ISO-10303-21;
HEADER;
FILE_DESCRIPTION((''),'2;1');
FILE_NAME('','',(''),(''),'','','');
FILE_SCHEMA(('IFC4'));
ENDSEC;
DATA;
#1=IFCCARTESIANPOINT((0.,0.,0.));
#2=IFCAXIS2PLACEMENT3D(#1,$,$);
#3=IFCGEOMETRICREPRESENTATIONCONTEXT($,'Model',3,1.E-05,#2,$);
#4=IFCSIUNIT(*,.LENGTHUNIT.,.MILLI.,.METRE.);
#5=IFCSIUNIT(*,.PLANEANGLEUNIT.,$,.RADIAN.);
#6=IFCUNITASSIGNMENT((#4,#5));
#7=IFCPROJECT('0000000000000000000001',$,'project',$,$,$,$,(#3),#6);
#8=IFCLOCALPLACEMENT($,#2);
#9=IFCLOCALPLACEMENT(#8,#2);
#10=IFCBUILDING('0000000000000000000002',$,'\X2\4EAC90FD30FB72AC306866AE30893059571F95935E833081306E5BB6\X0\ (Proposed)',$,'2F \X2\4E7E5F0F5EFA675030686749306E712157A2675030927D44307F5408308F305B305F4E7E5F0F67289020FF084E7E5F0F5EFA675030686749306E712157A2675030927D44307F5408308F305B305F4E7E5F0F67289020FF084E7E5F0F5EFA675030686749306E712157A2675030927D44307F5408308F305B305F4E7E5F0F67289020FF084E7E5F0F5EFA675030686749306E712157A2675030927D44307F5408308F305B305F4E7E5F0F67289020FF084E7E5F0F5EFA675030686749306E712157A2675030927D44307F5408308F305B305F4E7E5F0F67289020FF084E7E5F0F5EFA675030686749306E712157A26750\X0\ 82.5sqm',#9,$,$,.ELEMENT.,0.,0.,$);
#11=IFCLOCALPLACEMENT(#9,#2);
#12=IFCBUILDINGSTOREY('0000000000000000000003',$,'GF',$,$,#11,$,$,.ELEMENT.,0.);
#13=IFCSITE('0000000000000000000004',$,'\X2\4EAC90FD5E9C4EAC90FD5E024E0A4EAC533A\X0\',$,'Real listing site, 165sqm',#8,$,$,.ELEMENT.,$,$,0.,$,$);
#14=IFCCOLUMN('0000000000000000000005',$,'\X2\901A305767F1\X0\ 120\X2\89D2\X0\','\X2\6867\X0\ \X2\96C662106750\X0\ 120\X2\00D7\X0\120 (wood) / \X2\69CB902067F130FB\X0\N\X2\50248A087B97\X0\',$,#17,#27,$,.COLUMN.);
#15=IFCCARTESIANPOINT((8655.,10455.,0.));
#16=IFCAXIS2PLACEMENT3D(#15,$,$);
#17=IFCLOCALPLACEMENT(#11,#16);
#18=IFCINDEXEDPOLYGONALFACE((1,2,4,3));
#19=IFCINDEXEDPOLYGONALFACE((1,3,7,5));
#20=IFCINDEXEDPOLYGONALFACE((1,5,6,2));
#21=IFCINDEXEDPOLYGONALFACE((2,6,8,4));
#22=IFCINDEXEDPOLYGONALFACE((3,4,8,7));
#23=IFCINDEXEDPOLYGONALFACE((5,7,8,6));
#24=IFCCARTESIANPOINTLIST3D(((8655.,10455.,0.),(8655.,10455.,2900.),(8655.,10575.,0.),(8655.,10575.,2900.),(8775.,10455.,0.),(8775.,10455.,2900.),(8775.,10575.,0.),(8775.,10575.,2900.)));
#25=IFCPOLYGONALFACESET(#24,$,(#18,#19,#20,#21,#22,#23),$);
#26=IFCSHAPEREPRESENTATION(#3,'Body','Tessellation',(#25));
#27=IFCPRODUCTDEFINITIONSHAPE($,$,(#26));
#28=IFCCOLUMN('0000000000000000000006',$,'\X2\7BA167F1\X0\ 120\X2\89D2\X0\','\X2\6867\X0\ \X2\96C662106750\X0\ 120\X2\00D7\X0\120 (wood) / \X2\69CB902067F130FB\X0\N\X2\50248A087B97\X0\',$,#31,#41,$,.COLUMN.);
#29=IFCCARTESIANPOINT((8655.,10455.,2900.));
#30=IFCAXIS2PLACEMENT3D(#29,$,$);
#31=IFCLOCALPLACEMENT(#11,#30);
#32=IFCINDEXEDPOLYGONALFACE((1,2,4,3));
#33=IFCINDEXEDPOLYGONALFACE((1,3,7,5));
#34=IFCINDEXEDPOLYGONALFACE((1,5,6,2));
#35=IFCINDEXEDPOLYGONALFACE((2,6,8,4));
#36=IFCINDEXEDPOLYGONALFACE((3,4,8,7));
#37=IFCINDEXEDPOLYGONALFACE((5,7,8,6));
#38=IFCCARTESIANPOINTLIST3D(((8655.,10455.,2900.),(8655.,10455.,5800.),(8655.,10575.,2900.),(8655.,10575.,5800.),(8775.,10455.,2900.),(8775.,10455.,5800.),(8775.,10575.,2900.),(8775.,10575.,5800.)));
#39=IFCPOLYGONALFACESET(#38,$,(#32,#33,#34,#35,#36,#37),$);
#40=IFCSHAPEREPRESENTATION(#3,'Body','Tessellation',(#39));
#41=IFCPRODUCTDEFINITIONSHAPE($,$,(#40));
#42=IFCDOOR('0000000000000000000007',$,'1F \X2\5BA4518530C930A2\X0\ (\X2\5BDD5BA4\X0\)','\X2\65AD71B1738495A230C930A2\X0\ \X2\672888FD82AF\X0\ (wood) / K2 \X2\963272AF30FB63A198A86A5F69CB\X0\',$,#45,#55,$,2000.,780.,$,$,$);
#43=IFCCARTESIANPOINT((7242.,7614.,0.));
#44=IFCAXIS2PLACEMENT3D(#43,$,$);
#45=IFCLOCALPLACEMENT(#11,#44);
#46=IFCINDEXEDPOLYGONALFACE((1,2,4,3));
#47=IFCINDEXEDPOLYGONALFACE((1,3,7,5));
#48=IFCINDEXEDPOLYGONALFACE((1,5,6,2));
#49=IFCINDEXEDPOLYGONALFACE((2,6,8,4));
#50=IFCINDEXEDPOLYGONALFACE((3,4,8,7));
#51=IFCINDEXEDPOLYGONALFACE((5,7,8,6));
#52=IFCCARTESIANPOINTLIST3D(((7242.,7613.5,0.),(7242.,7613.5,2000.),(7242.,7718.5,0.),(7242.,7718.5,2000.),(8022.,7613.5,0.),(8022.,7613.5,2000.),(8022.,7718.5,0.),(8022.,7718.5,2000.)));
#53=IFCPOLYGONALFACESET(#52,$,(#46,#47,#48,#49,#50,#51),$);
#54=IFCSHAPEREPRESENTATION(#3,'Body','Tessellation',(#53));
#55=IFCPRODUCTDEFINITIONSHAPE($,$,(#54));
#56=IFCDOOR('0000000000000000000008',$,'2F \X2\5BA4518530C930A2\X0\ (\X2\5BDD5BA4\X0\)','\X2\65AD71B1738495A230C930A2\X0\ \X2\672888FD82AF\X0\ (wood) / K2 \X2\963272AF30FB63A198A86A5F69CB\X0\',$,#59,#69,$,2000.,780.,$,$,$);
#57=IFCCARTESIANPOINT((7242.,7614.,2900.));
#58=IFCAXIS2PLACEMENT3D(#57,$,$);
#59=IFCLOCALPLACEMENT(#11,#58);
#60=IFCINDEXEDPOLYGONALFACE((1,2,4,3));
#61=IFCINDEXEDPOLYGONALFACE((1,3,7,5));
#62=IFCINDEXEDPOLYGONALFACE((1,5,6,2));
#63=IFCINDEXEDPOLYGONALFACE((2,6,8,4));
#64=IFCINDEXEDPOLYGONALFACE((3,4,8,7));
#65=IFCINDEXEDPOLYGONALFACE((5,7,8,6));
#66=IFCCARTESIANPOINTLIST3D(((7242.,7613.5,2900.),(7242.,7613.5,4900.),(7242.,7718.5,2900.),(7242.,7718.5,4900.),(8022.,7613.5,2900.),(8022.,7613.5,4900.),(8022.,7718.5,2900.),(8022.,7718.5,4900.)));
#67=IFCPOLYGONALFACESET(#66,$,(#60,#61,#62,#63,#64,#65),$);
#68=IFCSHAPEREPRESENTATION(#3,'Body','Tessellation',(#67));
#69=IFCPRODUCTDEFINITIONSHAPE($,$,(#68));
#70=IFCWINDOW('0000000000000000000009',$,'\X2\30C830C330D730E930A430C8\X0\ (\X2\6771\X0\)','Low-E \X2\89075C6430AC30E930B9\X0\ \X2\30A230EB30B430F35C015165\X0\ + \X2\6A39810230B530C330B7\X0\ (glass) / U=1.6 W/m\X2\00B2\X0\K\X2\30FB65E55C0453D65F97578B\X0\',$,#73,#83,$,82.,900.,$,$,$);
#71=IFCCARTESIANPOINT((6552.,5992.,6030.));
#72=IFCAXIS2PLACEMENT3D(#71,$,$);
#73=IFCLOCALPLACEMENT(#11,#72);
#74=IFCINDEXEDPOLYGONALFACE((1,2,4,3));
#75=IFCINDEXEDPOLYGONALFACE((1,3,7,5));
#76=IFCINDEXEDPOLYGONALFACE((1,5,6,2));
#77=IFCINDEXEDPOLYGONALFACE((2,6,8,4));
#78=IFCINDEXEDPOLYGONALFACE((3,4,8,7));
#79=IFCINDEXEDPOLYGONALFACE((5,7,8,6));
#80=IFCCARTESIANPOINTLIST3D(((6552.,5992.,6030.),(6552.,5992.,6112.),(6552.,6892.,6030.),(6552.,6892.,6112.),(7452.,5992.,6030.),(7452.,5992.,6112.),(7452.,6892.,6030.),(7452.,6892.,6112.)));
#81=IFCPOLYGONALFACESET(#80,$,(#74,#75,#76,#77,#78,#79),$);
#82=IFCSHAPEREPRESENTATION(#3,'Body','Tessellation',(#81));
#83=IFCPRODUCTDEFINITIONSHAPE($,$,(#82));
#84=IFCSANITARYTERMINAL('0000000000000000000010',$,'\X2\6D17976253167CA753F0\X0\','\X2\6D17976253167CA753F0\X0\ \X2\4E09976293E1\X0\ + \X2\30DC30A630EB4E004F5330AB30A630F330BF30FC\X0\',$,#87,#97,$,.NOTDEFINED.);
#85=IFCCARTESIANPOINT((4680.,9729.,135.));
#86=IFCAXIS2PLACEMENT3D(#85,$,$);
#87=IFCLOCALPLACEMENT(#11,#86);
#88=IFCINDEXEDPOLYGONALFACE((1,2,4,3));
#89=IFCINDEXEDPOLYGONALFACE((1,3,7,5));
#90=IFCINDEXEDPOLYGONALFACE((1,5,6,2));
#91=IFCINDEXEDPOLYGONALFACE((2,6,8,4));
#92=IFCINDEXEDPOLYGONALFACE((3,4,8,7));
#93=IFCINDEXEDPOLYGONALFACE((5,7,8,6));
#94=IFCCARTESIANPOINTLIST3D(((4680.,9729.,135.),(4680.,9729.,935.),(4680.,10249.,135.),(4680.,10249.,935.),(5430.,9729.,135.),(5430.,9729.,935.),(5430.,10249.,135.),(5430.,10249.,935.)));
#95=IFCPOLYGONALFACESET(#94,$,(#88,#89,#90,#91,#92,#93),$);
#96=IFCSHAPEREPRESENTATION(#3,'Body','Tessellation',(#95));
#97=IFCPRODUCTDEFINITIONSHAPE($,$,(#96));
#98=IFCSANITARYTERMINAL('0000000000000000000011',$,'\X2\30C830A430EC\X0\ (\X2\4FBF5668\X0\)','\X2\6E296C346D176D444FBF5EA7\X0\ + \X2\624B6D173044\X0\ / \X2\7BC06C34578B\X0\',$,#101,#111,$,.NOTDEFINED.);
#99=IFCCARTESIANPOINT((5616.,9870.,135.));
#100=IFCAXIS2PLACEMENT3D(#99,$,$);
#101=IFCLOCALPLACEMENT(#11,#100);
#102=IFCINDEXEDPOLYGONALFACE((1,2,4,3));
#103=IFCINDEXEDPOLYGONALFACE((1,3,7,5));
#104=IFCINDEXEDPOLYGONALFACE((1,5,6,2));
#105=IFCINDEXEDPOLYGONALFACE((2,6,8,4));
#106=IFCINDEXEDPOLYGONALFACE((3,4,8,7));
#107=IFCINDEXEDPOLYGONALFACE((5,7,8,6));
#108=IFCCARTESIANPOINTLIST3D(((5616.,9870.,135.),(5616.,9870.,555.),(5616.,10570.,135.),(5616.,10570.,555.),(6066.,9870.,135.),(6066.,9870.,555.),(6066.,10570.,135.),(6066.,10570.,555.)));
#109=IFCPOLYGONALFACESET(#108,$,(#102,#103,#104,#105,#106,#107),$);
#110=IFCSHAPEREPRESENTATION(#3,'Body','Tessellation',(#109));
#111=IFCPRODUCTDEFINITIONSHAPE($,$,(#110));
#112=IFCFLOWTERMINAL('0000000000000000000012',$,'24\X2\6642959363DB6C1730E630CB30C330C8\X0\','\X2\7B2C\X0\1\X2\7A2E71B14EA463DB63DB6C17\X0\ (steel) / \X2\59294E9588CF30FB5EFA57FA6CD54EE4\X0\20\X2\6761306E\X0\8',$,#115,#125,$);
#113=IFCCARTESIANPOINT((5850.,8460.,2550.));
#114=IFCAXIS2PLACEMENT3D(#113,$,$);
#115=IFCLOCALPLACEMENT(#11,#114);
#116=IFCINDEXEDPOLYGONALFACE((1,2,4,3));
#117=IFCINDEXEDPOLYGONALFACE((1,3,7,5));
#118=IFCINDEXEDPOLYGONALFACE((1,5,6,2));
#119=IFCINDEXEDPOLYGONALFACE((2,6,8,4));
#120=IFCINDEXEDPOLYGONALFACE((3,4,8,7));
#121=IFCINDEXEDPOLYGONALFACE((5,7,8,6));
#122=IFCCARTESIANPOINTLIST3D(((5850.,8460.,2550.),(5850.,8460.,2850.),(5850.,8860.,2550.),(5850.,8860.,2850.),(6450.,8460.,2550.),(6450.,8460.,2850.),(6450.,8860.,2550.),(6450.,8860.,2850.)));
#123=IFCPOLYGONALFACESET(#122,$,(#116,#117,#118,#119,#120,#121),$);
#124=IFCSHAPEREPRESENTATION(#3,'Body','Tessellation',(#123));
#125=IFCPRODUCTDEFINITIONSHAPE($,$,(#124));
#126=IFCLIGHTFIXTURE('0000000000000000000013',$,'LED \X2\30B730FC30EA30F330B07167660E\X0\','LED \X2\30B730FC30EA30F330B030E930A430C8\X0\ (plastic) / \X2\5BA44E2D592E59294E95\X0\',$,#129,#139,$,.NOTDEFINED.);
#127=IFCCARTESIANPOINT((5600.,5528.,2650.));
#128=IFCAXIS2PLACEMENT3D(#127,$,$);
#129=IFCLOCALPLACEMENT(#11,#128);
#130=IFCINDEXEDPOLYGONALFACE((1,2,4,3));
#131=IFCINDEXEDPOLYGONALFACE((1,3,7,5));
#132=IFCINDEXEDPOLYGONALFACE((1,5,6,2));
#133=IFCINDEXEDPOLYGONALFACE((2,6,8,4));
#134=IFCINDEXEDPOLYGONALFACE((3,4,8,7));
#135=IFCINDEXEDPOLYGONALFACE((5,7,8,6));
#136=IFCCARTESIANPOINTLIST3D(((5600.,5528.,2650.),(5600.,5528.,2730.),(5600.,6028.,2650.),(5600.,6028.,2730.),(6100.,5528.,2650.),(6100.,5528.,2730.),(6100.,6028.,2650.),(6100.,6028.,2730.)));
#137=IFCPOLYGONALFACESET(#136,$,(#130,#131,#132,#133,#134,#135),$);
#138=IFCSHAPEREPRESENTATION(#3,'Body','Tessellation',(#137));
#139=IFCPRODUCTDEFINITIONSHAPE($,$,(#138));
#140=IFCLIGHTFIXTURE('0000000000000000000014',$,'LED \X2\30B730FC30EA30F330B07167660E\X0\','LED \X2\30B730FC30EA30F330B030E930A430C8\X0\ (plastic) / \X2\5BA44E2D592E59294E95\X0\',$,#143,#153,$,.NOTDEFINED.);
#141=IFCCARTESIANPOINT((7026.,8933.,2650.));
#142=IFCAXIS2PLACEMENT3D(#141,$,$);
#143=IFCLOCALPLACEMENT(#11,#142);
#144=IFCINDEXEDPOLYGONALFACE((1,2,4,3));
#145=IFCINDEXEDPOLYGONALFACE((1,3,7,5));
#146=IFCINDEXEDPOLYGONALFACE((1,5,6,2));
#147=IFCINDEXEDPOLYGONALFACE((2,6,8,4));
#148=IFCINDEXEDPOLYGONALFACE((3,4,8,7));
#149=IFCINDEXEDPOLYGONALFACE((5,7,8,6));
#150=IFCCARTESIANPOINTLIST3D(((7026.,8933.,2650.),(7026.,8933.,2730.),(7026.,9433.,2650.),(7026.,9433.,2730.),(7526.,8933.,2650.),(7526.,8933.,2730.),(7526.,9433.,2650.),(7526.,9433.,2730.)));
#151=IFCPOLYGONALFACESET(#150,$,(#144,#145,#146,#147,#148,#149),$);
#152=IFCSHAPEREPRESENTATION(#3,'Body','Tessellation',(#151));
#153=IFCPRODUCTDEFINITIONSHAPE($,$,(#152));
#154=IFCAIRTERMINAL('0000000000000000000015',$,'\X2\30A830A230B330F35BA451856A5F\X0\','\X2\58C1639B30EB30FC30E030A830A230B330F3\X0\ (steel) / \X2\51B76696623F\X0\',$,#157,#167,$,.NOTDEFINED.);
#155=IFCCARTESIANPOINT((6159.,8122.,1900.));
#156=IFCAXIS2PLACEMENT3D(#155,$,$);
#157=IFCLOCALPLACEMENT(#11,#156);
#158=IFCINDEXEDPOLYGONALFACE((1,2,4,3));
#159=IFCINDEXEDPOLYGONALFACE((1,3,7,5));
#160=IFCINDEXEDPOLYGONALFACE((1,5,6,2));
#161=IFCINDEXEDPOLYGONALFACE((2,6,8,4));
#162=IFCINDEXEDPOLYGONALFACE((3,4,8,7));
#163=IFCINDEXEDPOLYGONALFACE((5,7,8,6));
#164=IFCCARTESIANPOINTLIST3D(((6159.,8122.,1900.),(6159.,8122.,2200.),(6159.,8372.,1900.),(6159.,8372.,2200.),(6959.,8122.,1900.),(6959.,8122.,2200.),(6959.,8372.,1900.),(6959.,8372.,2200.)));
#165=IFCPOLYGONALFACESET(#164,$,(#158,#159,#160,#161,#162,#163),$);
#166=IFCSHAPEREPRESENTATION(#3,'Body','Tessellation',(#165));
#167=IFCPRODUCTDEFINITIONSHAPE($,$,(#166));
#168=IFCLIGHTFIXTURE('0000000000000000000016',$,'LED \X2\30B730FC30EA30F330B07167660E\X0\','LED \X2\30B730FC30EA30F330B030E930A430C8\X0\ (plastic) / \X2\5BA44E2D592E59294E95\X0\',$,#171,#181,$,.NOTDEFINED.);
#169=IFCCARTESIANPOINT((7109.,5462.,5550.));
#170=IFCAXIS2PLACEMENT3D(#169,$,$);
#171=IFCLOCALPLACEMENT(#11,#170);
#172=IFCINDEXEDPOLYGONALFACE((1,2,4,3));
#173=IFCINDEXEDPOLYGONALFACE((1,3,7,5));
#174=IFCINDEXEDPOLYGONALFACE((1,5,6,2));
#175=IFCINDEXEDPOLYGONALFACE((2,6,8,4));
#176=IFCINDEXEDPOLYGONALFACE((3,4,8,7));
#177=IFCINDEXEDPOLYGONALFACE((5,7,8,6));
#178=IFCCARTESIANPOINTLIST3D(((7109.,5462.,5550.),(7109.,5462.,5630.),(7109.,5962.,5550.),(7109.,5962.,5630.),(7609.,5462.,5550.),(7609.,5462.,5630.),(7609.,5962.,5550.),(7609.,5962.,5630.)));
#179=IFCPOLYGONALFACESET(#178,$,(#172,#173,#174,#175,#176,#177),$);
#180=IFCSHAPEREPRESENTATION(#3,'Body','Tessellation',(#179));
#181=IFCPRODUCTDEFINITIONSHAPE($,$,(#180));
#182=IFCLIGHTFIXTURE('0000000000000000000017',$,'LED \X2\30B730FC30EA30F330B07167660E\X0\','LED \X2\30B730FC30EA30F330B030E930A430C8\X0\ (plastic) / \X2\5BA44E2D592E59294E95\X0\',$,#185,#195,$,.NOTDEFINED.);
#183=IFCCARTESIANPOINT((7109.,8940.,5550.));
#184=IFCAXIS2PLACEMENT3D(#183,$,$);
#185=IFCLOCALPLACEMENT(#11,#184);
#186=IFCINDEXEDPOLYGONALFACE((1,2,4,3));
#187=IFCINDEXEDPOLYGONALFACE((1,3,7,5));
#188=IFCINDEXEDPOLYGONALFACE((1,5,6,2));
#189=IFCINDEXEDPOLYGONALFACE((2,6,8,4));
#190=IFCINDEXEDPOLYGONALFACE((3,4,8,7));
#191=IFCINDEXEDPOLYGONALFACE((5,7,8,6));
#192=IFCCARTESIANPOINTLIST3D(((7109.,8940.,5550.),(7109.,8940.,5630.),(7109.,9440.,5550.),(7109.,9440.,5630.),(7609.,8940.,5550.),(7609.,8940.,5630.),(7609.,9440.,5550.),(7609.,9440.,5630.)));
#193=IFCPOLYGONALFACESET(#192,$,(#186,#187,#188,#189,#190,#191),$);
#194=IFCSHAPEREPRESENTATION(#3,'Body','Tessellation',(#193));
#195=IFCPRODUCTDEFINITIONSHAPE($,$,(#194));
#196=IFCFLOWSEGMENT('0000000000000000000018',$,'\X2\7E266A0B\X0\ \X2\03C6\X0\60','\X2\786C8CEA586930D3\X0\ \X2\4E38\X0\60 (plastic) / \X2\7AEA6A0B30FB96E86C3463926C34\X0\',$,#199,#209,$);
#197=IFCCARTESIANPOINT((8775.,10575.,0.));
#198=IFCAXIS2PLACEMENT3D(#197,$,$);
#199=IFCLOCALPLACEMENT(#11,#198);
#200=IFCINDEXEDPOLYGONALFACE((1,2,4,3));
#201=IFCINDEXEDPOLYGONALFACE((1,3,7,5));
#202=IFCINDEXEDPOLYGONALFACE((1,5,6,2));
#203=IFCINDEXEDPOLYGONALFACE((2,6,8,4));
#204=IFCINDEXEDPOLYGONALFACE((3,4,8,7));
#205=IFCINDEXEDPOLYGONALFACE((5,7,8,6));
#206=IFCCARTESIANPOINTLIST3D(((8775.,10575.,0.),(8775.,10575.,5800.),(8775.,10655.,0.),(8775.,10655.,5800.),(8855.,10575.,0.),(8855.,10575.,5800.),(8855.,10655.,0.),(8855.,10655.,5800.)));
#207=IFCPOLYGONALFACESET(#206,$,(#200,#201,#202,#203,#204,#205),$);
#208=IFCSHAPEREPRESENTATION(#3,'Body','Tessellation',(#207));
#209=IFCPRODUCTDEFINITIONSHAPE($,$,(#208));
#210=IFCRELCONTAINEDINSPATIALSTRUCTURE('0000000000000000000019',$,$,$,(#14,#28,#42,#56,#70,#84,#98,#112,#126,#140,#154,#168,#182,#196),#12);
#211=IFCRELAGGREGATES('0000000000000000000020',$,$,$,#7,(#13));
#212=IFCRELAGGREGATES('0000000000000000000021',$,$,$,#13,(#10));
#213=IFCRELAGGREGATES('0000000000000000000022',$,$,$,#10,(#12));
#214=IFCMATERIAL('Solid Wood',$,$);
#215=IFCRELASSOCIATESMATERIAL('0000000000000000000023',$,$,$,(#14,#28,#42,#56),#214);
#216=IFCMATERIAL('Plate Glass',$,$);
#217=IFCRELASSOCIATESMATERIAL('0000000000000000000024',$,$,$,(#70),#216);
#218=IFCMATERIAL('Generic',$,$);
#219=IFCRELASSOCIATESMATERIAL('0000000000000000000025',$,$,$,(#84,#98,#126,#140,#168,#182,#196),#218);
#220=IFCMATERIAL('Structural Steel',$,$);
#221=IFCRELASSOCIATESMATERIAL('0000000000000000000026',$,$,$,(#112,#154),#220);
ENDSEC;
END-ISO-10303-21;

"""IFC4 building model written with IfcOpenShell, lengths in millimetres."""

from ifc_helpers import new_model, si_unit, frame, frame_2d, origin, place, context, project, spatial, rectangle, extrude, material, element, save


model = new_model("IFC4")

# Units and contexts
model_context = context("Model", 3, precision=1e-05, world=origin())
ifc_project = project(units=[si_unit("LENGTHUNIT", "METRE", prefix="MILLI"), si_unit("PLANEANGLEUNIT", "RADIAN")], contexts=[model_context])

# Site, building, storey
site_placement = place(None, origin())
site = spatial("IfcSite", under=ifc_project, at=site_placement, Name="京都府京都市上京区", ObjectType="Real listing site, 165sqm", CompositionType="ELEMENT", RefElevation=0.0)
building_placement = place(site_placement, origin())
building = spatial("IfcBuilding", under=site, at=building_placement, Name="京都・犬と暮らす土間広めの家 (Proposed)", ObjectType="2F 乾式建材と杉の無垢材を組み合わせた乾式木造（乾式建材と杉の無垢材を組み合わせた乾式木造（乾式建材と杉の無垢材を組み合わせた乾式木造（乾式建材と杉の無垢材を組み合わせた乾式木造（乾式建材と杉の無垢材を組み合わせた乾式木造（乾式建材と杉の無垢材 82.5sqm", CompositionType="ELEMENT", ElevationOfRefHeight=0.0, ElevationOfTerrain=0.0)
storey_placement = place(building_placement, origin())
storey = spatial("IfcBuildingStorey", under=building, at=storey_placement, Name="GF", CompositionType="ELEMENT", Elevation=0.0)

# Columns
ifc_material_1 = material(Name="Solid Wood")
column_1_placement = place(storey_placement, frame((8655.0, 10455.0, 0.0)))
element("IfcColumn", 1, at=column_1_placement, inside=storey, material=ifc_material_1, Name="通し柱 120角", Description="桧 集成材 120×120 (wood) / 構造柱・N値計算", PredefinedType="COLUMN", context=model_context, shape_type="SweptSolid", body=[
    extrude(rectangle(XDim=120.0, YDim=120.0, at=frame_2d((60.0, 60.0))), frame((8655.0, 10455.0, 0.0)), (0.0, 0.0, 1.0), 2900.0),
])
column_2_placement = place(storey_placement, frame((8655.0, 10455.0, 2900.0)))
element("IfcColumn", 2, at=column_2_placement, inside=storey, material=ifc_material_1, Name="管柱 120角", Description="桧 集成材 120×120 (wood) / 構造柱・N値計算", PredefinedType="COLUMN", context=model_context, shape_type="SweptSolid", body=[
    extrude(rectangle(XDim=120.0, YDim=120.0, at=frame_2d((60.0, 60.0))), frame((8655.0, 10455.0, 2900.0)), (0.0, 0.0, 1.0), 2900.0),
])

# Door
door_1_placement = place(storey_placement, frame((7242.0, 7614.0, 0.0)))
element("IfcDoor", 3, at=door_1_placement, inside=storey, material=ifc_material_1, Name="1F 室内ドア (寝室)", Description="断熱玄関ドア 木製芯 (wood) / K2 防犯・採風機構", OverallHeight=2000.0, OverallWidth=780.0, context=model_context, shape_type="SweptSolid", body=[
    extrude(rectangle(XDim=780.0, YDim=105.0, at=frame_2d((390.0, 52.0))), frame((7242.0, 7614.0, 0.0)), (0.0, 0.0, 1.0), 2000.0),
])

# Door
door_2_placement = place(storey_placement, frame((7242.0, 7614.0, 2900.0)))
element("IfcDoor", 4, at=door_2_placement, inside=storey, material=ifc_material_1, Name="2F 室内ドア (寝室)", Description="断熱玄関ドア 木製芯 (wood) / K2 防犯・採風機構", OverallHeight=2000.0, OverallWidth=780.0, context=model_context, shape_type="SweptSolid", body=[
    extrude(rectangle(XDim=780.0, YDim=105.0, at=frame_2d((390.0, 52.0))), frame((7242.0, 7614.0, 2900.0)), (0.0, 0.0, 1.0), 2000.0),
])

# Window
ifc_material_2 = material(Name="Plate Glass")
window_placement = place(storey_placement, frame((6552.0, 5992.0, 6030.0)))
element("IfcWindow", 5, at=window_placement, inside=storey, material=ifc_material_2, Name="トップライト (東)", Description="Low-E 複層ガラス アルゴン封入 + 樹脂サッシ (glass) / U=1.6 W/m²K・日射取得型", OverallHeight=82.0, OverallWidth=900.0, context=model_context, shape_type="SweptSolid", body=[
    extrude(rectangle(XDim=900.0, YDim=900.0, at=frame_2d((450.0, 450.0))), frame((6552.0, 5992.0, 6030.0)), (0.0, 0.0, 1.0), 82.0),
])

# Sanitary terminals
ifc_material_3 = material(Name="Generic")
sanitary_terminal_1_placement = place(storey_placement, frame((4680.0, 9729.0, 135.0)))
element("IfcSanitaryTerminal", 6, at=sanitary_terminal_1_placement, inside=storey, material=ifc_material_3, Name="洗面化粧台", Description="洗面化粧台 三面鏡 + ボウル一体カウンター", PredefinedType="NOTDEFINED", context=model_context, shape_type="SweptSolid", body=[
    extrude(rectangle(XDim=750.0, YDim=520.0, at=frame_2d((375.0, 260.0))), frame((4680.0, 9729.0, 135.0)), (0.0, 0.0, 1.0), 800.0),
])
sanitary_terminal_2_placement = place(storey_placement, frame((5616.0, 9870.0, 135.0)))
element("IfcSanitaryTerminal", 7, at=sanitary_terminal_2_placement, inside=storey, material=ifc_material_3, Name="トイレ (便器)", Description="温水洗浄便座 + 手洗い / 節水型", PredefinedType="NOTDEFINED", context=model_context, shape_type="SweptSolid", body=[
    extrude(rectangle(XDim=450.0, YDim=700.0, at=frame_2d((225.0, 350.0))), frame((5616.0, 9870.0, 135.0)), (0.0, 0.0, 1.0), 420.0),
])

# Flow terminal
ifc_material_4 = material(Name="Structural Steel")
flow_terminal_placement = place(storey_placement, frame((5850.0, 8460.0, 2550.0)))
element("IfcFlowTerminal", 8, at=flow_terminal_placement, inside=storey, material=ifc_material_4, Name="24時間換気ユニット", Description="第1種熱交換換気 (steel) / 天井裏・建基法令20条の8", context=model_context, shape_type="SweptSolid", body=[
    extrude(rectangle(XDim=600.0, YDim=400.0, at=frame_2d((300.0, 200.0))), frame((5850.0, 8460.0, 2550.0)), (0.0, 0.0, 1.0), 300.0),
])

# Light fixtures
light_fixture_1_placement = place(storey_placement, frame((5600.0, 5528.0, 2650.0)))
element("IfcLightFixture", 9, at=light_fixture_1_placement, inside=storey, material=ifc_material_3, Name="LED シーリング照明", Description="LED シーリングライト (plastic) / 室中央天井", PredefinedType="NOTDEFINED", context=model_context, shape_type="SweptSolid", body=[
    extrude(rectangle(XDim=500.0, YDim=500.0, at=frame_2d((250.0, 250.0))), frame((5600.0, 5528.0, 2650.0)), (0.0, 0.0, 1.0), 80.0),
])
light_fixture_2_placement = place(storey_placement, frame((7026.0, 8933.0, 2650.0)))
element("IfcLightFixture", 10, at=light_fixture_2_placement, inside=storey, material=ifc_material_3, Name="LED シーリング照明", Description="LED シーリングライト (plastic) / 室中央天井", PredefinedType="NOTDEFINED", context=model_context, shape_type="SweptSolid", body=[
    extrude(rectangle(XDim=500.0, YDim=500.0, at=frame_2d((250.0, 250.0))), frame((7026.0, 8933.0, 2650.0)), (0.0, 0.0, 1.0), 80.0),
])

# Air terminal
air_terminal_placement = place(storey_placement, frame((6159.0, 8122.0, 1900.0)))
element("IfcAirTerminal", 11, at=air_terminal_placement, inside=storey, material=ifc_material_4, Name="エアコン室内機", Description="壁掛ルームエアコン (steel) / 冷暖房", PredefinedType="NOTDEFINED", context=model_context, shape_type="SweptSolid", body=[
    extrude(rectangle(XDim=800.0, YDim=250.0, at=frame_2d((400.0, 125.0))), frame((6159.0, 8122.0, 1900.0)), (0.0, 0.0, 1.0), 300.0),
])

# Light fixtures
light_fixture_3_placement = place(storey_placement, frame((7109.0, 5462.0, 5550.0)))
element("IfcLightFixture", 12, at=light_fixture_3_placement, inside=storey, material=ifc_material_3, Name="LED シーリング照明", Description="LED シーリングライト (plastic) / 室中央天井", PredefinedType="NOTDEFINED", context=model_context, shape_type="SweptSolid", body=[
    extrude(rectangle(XDim=500.0, YDim=500.0, at=frame_2d((250.0, 250.0))), frame((7109.0, 5462.0, 5550.0)), (0.0, 0.0, 1.0), 80.0),
])
light_fixture_4_placement = place(storey_placement, frame((7109.0, 8940.0, 5550.0)))
element("IfcLightFixture", 13, at=light_fixture_4_placement, inside=storey, material=ifc_material_3, Name="LED シーリング照明", Description="LED シーリングライト (plastic) / 室中央天井", PredefinedType="NOTDEFINED", context=model_context, shape_type="SweptSolid", body=[
    extrude(rectangle(XDim=500.0, YDim=500.0, at=frame_2d((250.0, 250.0))), frame((7109.0, 8940.0, 5550.0)), (0.0, 0.0, 1.0), 80.0),
])

# Flow segment
flow_segment_placement = place(storey_placement, frame((8775.0, 10575.0, 0.0)))
element("IfcFlowSegment", 14, at=flow_segment_placement, inside=storey, material=ifc_material_3, Name="縦樋 φ60", Description="硬質塩ビ 丸60 (plastic) / 竪樋・雨水排水", context=model_context, shape_type="SweptSolid", body=[
    extrude(rectangle(XDim=80.0, YDim=80.0, at=frame_2d((40.0, 40.0))), frame((8775.0, 10575.0, 0.0)), (0.0, 0.0, 1.0), 5800.0),
])

save(model, "model.ifc")
